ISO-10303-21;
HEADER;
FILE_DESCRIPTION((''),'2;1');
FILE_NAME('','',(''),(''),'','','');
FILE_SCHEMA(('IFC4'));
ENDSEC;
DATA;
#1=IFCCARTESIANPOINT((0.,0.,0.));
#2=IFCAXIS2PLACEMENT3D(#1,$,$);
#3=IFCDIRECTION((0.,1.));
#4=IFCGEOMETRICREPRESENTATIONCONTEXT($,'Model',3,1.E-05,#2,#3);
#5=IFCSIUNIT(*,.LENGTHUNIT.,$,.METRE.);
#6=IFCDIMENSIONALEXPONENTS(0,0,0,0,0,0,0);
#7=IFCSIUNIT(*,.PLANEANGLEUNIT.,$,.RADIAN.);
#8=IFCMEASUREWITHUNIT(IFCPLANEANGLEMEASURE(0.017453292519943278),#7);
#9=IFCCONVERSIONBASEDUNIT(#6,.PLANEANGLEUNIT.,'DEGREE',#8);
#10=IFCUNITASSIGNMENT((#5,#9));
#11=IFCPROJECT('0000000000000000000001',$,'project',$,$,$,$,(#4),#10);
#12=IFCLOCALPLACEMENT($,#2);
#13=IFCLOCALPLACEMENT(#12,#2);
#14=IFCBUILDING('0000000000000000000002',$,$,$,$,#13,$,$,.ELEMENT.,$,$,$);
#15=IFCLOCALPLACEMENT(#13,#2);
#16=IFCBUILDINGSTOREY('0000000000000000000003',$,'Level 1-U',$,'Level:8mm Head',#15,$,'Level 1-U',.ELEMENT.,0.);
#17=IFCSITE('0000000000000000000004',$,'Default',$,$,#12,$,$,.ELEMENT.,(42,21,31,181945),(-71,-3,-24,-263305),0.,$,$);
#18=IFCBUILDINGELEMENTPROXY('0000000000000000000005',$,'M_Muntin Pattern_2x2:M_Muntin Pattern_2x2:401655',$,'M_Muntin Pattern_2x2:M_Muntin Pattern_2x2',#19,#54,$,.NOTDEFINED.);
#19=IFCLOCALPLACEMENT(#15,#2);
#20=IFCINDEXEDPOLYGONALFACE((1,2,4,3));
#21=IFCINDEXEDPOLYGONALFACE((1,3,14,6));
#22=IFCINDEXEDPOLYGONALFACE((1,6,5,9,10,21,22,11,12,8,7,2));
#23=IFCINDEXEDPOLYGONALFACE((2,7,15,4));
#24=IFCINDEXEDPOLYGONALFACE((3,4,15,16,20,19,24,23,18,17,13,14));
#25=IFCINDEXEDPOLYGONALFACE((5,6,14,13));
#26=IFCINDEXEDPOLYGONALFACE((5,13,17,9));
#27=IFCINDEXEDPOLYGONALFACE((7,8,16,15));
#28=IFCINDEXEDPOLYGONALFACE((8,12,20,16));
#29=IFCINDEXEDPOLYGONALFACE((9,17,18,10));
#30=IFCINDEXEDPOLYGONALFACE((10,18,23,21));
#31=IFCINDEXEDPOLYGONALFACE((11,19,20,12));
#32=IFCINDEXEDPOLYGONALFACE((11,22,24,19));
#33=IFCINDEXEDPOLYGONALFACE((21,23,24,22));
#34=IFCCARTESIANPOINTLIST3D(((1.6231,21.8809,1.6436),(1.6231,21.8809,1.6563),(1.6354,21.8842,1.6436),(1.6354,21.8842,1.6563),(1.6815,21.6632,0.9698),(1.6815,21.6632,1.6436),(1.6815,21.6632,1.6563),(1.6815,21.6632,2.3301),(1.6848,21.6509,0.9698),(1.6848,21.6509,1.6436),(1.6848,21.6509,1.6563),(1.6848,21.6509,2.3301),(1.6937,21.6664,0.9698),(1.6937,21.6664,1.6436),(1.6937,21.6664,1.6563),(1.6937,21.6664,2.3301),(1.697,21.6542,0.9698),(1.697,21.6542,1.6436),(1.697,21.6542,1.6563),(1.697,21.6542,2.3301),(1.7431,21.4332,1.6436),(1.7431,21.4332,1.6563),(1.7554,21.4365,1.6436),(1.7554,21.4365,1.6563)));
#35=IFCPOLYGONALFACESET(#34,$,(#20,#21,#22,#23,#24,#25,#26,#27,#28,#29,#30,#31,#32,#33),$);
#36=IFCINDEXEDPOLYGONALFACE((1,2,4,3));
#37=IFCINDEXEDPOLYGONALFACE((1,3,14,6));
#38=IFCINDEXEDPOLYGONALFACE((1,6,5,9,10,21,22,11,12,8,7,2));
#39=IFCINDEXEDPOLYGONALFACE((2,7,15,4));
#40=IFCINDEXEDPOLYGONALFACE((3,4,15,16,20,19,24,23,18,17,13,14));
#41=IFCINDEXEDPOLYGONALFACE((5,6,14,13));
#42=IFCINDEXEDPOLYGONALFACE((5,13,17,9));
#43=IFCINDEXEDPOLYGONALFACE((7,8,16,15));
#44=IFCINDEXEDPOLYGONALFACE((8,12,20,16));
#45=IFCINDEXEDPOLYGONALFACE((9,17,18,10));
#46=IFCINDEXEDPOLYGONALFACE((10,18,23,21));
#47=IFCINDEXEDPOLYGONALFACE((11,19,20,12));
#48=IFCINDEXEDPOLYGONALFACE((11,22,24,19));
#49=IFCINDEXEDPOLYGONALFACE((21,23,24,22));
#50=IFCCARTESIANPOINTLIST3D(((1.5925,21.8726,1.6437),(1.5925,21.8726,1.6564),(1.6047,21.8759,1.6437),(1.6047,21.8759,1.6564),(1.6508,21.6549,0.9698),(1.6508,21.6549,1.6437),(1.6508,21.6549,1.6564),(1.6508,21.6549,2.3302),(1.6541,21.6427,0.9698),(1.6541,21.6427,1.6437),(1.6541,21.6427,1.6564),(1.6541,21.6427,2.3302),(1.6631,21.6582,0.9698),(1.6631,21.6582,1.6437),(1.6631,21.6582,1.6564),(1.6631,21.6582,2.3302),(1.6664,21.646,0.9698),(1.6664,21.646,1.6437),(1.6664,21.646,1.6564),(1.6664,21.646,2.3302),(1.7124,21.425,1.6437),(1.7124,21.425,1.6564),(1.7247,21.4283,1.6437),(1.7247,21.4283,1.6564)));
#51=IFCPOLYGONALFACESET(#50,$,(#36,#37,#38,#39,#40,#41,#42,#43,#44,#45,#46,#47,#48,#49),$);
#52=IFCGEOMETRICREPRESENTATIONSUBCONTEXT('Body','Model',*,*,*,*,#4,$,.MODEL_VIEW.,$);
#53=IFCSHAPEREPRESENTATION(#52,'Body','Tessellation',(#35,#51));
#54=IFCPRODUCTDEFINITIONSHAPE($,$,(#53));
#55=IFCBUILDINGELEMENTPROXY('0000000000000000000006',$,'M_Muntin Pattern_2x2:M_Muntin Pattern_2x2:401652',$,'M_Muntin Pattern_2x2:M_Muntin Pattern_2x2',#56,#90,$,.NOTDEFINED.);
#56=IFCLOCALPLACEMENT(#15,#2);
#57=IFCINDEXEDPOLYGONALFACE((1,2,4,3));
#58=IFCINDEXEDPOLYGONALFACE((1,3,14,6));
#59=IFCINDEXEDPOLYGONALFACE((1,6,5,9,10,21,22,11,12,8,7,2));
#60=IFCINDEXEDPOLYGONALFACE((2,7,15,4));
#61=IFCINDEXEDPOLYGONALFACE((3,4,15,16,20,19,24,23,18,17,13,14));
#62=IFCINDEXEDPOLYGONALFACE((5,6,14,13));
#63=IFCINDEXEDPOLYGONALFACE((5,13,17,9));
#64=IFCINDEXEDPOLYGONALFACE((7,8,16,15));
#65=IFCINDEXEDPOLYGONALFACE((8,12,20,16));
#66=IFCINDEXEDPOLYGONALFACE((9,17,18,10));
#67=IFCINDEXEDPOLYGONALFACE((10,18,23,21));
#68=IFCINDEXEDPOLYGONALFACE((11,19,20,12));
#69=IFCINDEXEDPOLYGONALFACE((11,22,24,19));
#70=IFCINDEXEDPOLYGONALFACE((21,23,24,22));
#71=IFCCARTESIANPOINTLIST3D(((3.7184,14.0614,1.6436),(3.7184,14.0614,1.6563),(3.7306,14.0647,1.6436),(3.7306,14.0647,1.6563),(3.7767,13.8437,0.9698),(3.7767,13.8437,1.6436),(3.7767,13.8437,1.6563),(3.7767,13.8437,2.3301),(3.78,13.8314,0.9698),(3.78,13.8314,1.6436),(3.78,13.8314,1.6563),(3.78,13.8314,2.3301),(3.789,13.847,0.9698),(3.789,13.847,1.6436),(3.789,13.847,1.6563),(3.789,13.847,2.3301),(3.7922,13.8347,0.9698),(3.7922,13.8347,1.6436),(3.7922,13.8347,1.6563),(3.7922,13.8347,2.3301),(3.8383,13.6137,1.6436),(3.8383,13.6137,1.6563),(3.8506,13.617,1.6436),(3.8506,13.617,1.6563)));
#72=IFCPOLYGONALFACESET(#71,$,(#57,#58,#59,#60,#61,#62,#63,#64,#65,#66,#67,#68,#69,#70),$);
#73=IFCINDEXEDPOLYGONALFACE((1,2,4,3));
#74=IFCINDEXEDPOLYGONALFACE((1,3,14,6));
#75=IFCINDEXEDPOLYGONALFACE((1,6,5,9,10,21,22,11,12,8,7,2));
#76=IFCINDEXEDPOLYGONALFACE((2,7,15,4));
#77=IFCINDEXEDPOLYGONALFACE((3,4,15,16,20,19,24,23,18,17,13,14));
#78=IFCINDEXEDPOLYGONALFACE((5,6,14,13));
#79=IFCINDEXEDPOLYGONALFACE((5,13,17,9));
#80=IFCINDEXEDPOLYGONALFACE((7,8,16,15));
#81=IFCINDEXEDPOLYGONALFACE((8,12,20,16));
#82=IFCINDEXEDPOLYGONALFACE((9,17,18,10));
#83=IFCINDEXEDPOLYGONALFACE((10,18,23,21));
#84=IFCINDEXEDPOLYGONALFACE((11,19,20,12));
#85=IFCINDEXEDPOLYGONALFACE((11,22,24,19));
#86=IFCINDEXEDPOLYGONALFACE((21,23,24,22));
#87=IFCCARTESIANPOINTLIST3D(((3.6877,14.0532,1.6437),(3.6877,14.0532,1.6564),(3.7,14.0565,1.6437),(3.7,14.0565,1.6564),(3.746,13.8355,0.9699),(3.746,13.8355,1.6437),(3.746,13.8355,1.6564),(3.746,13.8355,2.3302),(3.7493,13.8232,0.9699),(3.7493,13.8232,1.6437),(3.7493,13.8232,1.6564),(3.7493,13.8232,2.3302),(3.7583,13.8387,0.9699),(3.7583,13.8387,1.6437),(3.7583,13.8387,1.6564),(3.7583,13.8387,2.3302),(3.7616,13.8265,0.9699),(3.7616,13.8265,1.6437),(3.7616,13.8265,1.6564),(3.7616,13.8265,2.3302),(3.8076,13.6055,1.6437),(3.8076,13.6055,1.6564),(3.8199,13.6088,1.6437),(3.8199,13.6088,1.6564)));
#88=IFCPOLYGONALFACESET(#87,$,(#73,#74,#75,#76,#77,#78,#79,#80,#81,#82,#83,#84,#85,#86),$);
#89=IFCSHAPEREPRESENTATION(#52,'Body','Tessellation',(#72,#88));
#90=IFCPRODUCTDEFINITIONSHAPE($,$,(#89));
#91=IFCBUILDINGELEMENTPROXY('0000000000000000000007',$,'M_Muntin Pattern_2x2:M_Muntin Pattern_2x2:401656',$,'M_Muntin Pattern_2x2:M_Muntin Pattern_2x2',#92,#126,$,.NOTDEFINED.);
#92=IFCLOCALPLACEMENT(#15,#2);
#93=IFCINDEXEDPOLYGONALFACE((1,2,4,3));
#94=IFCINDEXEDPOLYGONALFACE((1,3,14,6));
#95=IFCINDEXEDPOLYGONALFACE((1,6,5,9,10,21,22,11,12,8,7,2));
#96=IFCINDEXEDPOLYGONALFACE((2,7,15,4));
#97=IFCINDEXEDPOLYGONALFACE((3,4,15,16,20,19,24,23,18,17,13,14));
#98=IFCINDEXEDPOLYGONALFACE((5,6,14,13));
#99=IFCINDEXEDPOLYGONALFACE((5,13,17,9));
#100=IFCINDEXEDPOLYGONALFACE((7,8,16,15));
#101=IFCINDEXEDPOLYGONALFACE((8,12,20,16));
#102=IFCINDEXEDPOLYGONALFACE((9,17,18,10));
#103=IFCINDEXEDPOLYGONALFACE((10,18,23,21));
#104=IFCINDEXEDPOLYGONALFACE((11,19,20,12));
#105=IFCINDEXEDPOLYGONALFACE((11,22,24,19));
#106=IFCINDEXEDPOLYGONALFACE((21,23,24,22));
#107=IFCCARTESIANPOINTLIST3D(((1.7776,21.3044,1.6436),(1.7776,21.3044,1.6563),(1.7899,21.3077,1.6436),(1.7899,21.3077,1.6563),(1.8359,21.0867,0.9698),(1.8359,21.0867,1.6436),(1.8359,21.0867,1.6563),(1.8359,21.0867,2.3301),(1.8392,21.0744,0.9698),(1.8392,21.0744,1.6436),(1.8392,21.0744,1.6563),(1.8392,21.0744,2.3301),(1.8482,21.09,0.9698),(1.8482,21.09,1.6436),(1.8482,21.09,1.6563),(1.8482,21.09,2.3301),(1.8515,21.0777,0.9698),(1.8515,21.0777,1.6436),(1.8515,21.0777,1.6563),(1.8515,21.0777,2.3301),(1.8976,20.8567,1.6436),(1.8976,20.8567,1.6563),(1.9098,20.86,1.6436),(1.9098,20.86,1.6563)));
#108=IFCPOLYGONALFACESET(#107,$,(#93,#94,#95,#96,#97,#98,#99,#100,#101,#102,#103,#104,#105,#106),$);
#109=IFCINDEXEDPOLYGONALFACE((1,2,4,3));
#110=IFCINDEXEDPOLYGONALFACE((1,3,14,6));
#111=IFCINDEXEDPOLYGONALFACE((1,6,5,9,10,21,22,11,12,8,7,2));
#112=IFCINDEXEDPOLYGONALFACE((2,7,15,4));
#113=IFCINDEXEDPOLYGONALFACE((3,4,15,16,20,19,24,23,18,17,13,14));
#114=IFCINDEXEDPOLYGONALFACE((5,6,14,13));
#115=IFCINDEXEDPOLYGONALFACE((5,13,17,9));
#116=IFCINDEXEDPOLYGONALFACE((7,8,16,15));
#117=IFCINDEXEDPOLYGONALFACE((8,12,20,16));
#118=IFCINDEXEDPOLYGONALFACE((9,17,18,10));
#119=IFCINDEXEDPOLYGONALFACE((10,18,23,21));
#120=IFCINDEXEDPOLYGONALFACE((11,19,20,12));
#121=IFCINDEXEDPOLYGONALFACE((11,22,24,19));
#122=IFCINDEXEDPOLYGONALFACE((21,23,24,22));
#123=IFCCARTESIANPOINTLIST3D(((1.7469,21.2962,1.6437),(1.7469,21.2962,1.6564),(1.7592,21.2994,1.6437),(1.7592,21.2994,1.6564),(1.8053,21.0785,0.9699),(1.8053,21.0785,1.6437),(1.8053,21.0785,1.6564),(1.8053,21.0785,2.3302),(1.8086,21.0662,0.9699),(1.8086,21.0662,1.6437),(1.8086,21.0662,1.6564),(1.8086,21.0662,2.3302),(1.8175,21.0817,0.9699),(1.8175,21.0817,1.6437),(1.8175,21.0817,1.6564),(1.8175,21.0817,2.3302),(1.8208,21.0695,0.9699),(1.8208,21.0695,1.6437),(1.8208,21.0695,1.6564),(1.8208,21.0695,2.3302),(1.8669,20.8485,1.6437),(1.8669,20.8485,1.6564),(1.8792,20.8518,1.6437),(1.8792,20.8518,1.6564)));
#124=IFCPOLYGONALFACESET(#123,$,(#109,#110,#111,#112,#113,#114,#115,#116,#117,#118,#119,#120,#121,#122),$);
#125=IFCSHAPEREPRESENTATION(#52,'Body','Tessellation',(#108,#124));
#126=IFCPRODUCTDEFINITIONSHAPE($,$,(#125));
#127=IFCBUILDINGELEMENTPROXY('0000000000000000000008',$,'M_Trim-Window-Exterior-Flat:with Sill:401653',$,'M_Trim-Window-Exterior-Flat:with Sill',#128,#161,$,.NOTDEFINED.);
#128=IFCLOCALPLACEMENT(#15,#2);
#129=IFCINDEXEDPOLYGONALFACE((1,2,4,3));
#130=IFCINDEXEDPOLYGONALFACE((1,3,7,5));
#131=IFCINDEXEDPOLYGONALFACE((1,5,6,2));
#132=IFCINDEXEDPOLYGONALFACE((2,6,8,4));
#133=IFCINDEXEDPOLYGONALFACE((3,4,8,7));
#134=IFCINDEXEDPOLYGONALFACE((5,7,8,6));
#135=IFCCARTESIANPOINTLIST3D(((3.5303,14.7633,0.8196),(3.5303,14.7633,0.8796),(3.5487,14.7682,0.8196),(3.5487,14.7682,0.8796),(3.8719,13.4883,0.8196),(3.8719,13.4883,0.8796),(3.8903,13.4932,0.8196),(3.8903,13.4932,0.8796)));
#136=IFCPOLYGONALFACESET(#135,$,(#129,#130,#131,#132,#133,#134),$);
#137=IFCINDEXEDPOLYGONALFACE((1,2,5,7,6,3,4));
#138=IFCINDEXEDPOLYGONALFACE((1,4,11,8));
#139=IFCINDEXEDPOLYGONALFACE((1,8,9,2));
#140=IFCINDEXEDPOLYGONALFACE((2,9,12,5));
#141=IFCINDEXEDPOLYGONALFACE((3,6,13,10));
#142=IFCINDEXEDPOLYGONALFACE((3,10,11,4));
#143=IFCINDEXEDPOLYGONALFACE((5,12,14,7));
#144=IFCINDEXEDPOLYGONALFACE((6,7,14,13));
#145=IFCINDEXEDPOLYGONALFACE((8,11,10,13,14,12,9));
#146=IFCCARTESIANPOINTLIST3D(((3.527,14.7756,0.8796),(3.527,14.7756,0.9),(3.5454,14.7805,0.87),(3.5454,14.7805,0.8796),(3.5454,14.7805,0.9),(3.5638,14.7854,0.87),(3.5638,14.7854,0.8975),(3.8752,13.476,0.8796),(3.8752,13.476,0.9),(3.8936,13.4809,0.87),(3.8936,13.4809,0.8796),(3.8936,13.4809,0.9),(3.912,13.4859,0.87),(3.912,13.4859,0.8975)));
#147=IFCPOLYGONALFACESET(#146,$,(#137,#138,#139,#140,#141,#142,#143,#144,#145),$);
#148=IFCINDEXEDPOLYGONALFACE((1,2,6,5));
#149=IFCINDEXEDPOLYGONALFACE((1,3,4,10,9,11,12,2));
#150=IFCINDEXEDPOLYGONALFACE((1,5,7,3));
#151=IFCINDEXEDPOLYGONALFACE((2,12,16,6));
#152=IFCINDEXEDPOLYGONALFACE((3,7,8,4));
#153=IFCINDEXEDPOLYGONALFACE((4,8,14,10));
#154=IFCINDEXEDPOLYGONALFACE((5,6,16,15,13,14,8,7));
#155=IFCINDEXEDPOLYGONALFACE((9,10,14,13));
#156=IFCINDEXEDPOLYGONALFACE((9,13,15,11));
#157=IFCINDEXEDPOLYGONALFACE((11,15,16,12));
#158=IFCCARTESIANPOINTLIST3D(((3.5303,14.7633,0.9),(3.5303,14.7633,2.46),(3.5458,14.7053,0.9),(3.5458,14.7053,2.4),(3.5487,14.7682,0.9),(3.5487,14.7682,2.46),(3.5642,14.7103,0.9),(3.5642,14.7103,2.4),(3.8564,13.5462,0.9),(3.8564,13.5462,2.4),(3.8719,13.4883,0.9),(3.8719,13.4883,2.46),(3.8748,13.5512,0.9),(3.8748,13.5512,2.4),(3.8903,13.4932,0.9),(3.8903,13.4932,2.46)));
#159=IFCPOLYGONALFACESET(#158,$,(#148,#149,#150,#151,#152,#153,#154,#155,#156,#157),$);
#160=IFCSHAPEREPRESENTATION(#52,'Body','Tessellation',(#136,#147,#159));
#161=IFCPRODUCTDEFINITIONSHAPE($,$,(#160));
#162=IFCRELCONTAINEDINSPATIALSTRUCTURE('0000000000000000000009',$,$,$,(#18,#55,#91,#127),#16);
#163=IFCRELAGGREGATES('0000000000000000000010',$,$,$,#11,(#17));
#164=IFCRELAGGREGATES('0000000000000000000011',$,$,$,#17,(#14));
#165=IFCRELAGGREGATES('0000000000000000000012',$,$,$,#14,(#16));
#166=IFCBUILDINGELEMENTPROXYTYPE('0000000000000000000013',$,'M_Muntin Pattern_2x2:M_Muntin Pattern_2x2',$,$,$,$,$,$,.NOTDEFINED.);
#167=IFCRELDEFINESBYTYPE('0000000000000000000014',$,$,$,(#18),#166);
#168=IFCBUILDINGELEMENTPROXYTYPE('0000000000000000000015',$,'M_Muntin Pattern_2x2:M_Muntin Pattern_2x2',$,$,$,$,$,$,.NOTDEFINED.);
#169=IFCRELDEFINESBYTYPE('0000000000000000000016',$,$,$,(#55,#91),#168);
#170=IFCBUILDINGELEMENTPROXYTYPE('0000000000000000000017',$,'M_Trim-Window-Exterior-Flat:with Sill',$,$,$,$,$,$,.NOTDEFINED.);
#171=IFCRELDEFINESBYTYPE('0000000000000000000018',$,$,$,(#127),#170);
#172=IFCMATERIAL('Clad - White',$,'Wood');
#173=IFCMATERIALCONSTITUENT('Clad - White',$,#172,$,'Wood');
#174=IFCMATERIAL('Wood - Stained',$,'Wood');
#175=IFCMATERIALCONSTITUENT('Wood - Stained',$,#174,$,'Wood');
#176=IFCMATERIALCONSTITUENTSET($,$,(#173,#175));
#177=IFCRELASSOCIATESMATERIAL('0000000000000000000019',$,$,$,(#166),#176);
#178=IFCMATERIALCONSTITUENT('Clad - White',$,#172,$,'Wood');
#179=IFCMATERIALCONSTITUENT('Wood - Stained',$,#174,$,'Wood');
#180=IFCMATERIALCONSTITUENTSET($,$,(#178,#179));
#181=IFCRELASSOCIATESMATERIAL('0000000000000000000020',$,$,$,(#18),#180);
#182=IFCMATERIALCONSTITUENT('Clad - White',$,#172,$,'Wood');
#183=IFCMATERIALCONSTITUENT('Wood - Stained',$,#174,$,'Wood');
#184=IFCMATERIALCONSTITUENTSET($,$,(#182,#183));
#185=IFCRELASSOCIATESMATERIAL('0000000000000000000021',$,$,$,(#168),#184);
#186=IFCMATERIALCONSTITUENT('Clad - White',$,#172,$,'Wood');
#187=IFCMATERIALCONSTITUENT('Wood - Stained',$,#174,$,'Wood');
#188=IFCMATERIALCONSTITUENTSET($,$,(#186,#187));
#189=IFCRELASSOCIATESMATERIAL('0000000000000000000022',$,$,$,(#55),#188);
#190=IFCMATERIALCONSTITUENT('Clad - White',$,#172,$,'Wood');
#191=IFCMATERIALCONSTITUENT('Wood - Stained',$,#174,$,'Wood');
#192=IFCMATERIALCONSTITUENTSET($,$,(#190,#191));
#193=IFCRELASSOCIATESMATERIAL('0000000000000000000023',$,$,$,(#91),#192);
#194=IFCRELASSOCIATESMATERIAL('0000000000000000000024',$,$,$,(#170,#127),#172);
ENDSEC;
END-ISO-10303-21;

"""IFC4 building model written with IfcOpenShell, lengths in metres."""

from ifc_helpers import new_model, entity, si_unit, converted_unit, direction, frame, frame_2d, origin, place, context, subcontext, project, spatial, polyline, rectangle, outline, extrude, source, transform, mapped, material, constituent, constituent_set, type_object, type_shapes, element, save


model = new_model("IFC4")

# Units and contexts
model_context = context("Model", 3, precision=1e-05, world=origin(), true_north=direction((0.0, 1.0)))
body_context = subcontext(model_context, "Body", "Model", "MODEL_VIEW")
ifc_project = project(units=[si_unit("LENGTHUNIT", "METRE"), converted_unit("PLANEANGLEUNIT", "DEGREE", entity("IfcPlaneAngleMeasure", 0.017453292519943278), si_unit("PLANEANGLEUNIT", "RADIAN"), dimensions=[0, 0, 0, 0, 0, 0, 0])], contexts=[model_context])

# Site, building, storey
site_placement = place(None, origin())
site = spatial("IfcSite", under=ifc_project, at=site_placement, Name="Default", CompositionType="ELEMENT", RefLatitude=(42, 21, 31, 181945), RefLongitude=(-71, -3, -24, -263305), RefElevation=0.0)
building_placement = place(site_placement, origin())
building = spatial("IfcBuilding", under=site, at=building_placement, CompositionType="ELEMENT")
storey_placement = place(building_placement, origin())
storey = spatial("IfcBuildingStorey", under=building, at=storey_placement, Name="Level 1-U", ObjectType="Level:8mm Head", LongName="Level 1-U", CompositionType="ELEMENT", Elevation=0.0)

# Building element proxies
ifc_material_1 = material(Name="Clad - White", Category="Wood")
ifc_material_2 = material(Name="Wood - Stained", Category="Wood")
ifc_constituent_1 = constituent(ifc_material_1, Name="Clad - White", Category="Wood")
ifc_constituent_2 = constituent(ifc_material_2, Name="Wood - Stained", Category="Wood")
ifc_constituent_set_1 = constituent_set(constituents=[ifc_constituent_1, ifc_constituent_2])
building_element_proxy_type_1 = type_object("IfcBuildingElementProxyType", Name="M_Muntin Pattern_2x2:M_Muntin Pattern_2x2", PredefinedType="NOTDEFINED", material=ifc_constituent_set_1)
shared_shape_1 = source(origin(), body_context, "Body", "SweptSolid", [
    extrude(outline(polyline([(0.0064, -0.0064), (0.6801, -0.0064), (0.6801, 0.0063), (0.0064, 0.0063), (0.0064, 0.2317), (-0.0063, 0.2317), (-0.0063, 0.0063), (-0.6802, 0.0063), (-0.6802, -0.0064), (-0.0063, -0.0064), (-0.0063, -0.2317), (0.0064, -0.2317), (0.0064, -0.0064)])), frame((0.0, 0.0095, 0.6801), z_axis=(0.0, 1.0, 0.0), x_axis=(0.0, 0.0, 1.0)), (0.0, 0.0, 1.0), 0.0127),
    extrude(outline(polyline([(0.0064, -0.0064), (0.6802, -0.0064), (0.6802, 0.0063), (0.0064, 0.0063), (0.0064, 0.2317), (-0.0063, 0.2317), (-0.0063, 0.0063), (-0.6802, 0.0063), (-0.6802, -0.0064), (-0.0063, -0.0064), (-0.0063, -0.2317), (0.0064, -0.2317), (0.0064, -0.0064)])), frame((0.0, -0.0222, 0.6802), z_axis=(0.0, 1.0, 0.0), x_axis=(0.0, 0.0, 1.0)), (0.0, 0.0, 1.0), 0.0127),
])
type_shapes(building_element_proxy_type_1, [shared_shape_1])
ifc_constituent_3 = constituent(ifc_material_1, Name="Clad - White", Category="Wood")
ifc_constituent_4 = constituent(ifc_material_2, Name="Wood - Stained", Category="Wood")
ifc_constituent_set_2 = constituent_set(constituents=[ifc_constituent_3, ifc_constituent_4])
proxy_1_placement = place(storey_placement, frame((1.6739, 21.6546, 0.9698), z_axis=(0.0, 0.0, 1.0), x_axis=(0.258819, -0.965926, 0.0)))
element("IfcBuildingElementProxy", 1, at=proxy_1_placement, inside=storey, type_object=building_element_proxy_type_1, material=ifc_constituent_set_2, Name="M_Muntin Pattern_2x2:M_Muntin Pattern_2x2:401655", ObjectType="M_Muntin Pattern_2x2:M_Muntin Pattern_2x2", PredefinedType="NOTDEFINED", context=body_context, shape_type="MappedRepresentation", body=[
    mapped(shared_shape_1, transform((0.0, 0.0, 0.0), scale=1.0)),
])
ifc_constituent_5 = constituent(ifc_material_1, Name="Clad - White", Category="Wood")
ifc_constituent_6 = constituent(ifc_material_2, Name="Wood - Stained", Category="Wood")
ifc_constituent_set_3 = constituent_set(constituents=[ifc_constituent_5, ifc_constituent_6])
ifc_constituent_7 = constituent(ifc_material_1, Name="Clad - White", Category="Wood")
ifc_constituent_8 = constituent(ifc_material_2, Name="Wood - Stained", Category="Wood")
ifc_constituent_set_4 = constituent_set(constituents=[ifc_constituent_7, ifc_constituent_8])
building_element_proxy_type_2 = type_object("IfcBuildingElementProxyType", Name="M_Muntin Pattern_2x2:M_Muntin Pattern_2x2", PredefinedType="NOTDEFINED", material=ifc_constituent_set_4)
shared_shape_2 = source(origin(), body_context, "Body", "SweptSolid", [
    extrude(outline(polyline([(0.0064, -0.0064), (0.6801, -0.0064), (0.6801, 0.0063), (0.0064, 0.0063), (0.0064, 0.2317), (-0.0063, 0.2317), (-0.0063, 0.0063), (-0.6802, 0.0063), (-0.6802, -0.0064), (-0.0063, -0.0064), (-0.0063, -0.2317), (0.0064, -0.2317), (0.0064, -0.0064)])), frame((0.0, -0.0222, 0.6801), z_axis=(0.0, 1.0, 0.0), x_axis=(0.0, 0.0, 1.0)), (0.0, 0.0, 1.0), 0.0127),
    extrude(outline(polyline([(0.0064, -0.0064), (0.6802, -0.0064), (0.6802, 0.0063), (0.0064, 0.0063), (0.0064, 0.2317), (-0.0063, 0.2317), (-0.0063, 0.0063), (-0.6802, 0.0063), (-0.6802, -0.0064), (-0.0063, -0.0064), (-0.0063, -0.2317), (0.0064, -0.2317), (0.0064, -0.0064)])), frame((0.0, 0.0095, 0.6802), z_axis=(0.0, 1.0, 0.0), x_axis=(0.0, 0.0, 1.0)), (0.0, 0.0, 1.0), 0.0127),
])
type_shapes(building_element_proxy_type_2, [shared_shape_2])
proxy_2_placement = place(storey_placement, frame((3.7691, 13.8351, 0.9699), z_axis=(0.0, 0.0, 1.0), x_axis=(-0.258819, 0.965926, 0.0)))
element("IfcBuildingElementProxy", 2, at=proxy_2_placement, inside=storey, type_object=building_element_proxy_type_2, material=ifc_constituent_set_3, Name="M_Muntin Pattern_2x2:M_Muntin Pattern_2x2:401652", ObjectType="M_Muntin Pattern_2x2:M_Muntin Pattern_2x2", PredefinedType="NOTDEFINED", context=body_context, shape_type="MappedRepresentation", body=[
    mapped(shared_shape_2, transform((0.0, 0.0, 0.0), scale=1.0)),
])
ifc_constituent_9 = constituent(ifc_material_1, Name="Clad - White", Category="Wood")
ifc_constituent_10 = constituent(ifc_material_2, Name="Wood - Stained", Category="Wood")
ifc_constituent_set_5 = constituent_set(constituents=[ifc_constituent_9, ifc_constituent_10])
proxy_3_placement = place(storey_placement, frame((1.8284, 21.0781, 0.9699), z_axis=(0.0, 0.0, 1.0), x_axis=(-0.258819, 0.965926, 0.0)))
element("IfcBuildingElementProxy", 3, at=proxy_3_placement, inside=storey, type_object=building_element_proxy_type_2, material=ifc_constituent_set_5, Name="M_Muntin Pattern_2x2:M_Muntin Pattern_2x2:401656", ObjectType="M_Muntin Pattern_2x2:M_Muntin Pattern_2x2", PredefinedType="NOTDEFINED", context=body_context, shape_type="MappedRepresentation", body=[
    mapped(shared_shape_2, transform((0.0, 0.0, 0.0), scale=1.0)),
])
building_element_proxy_type_3 = type_object("IfcBuildingElementProxyType", Name="M_Trim-Window-Exterior-Flat:with Sill", PredefinedType="NOTDEFINED", material=ifc_material_1)
shared_shape_3 = source(origin(), body_context, "Body", "SweptSolid", [
    extrude(rectangle(XDim=1.32, YDim=0.06, at=frame_2d((0.0, 0.0), x_axis=(1.0, 0.0))), frame((0.0, -1.5504, 0.0), z_axis=(0.0, 0.0, 1.0), x_axis=(-1.0, 0.0, 0.0)), (0.0, 0.0, 1.0), 0.019),
    extrude(outline(polyline([(-0.019, -0.0152), (0.0, -0.0152), (0.0, -0.0057), (0.019, -0.0057), (0.019, 0.0148), (0.0, 0.0148), (-0.019, 0.0123), (-0.019, -0.0152)])), frame((-0.6727, -1.5148, 0.019), z_axis=(1.0, 0.0, 0.0), x_axis=(0.0, 0.0, -1.0)), (0.0, 0.0, 1.0), 1.3454),
    extrude(outline(polyline([(-0.795, -0.66), (0.765, -0.66), (0.765, -0.6), (-0.735, -0.6), (-0.735, 0.6), (0.765, 0.6), (0.765, 0.66), (-0.795, 0.66), (-0.795, -0.66)])), frame((0.0, -0.735, 0.0), z_axis=(0.0, 0.0, 1.0), x_axis=(0.0, -1.0, 0.0)), (0.0, 0.0, 1.0), 0.019),
])
type_shapes(building_element_proxy_type_3, [shared_shape_3])
for number, where, z_axis, x_axis, name in (
    (4, (3.7011, 14.1258, 2.4), (0.965926, 0.258819, 0.0), (-0.258819, 0.965926, 0.0), "M_Trim-Window-Exterior-Flat:with Sill:401653"),
):
    element("IfcBuildingElementProxy", number, at=place(storey_placement, frame(where, z_axis=z_axis, x_axis=x_axis)), inside=storey, type_object=building_element_proxy_type_3, material=ifc_material_1, Name=name, ObjectType="M_Trim-Window-Exterior-Flat:with Sill", PredefinedType="NOTDEFINED", context=body_context, shape_type="MappedRepresentation", body=[
        mapped(shared_shape_3, transform((0.0, 0.0, 0.0), scale=1.0)),
    ])

save(model, "model.ifc")
